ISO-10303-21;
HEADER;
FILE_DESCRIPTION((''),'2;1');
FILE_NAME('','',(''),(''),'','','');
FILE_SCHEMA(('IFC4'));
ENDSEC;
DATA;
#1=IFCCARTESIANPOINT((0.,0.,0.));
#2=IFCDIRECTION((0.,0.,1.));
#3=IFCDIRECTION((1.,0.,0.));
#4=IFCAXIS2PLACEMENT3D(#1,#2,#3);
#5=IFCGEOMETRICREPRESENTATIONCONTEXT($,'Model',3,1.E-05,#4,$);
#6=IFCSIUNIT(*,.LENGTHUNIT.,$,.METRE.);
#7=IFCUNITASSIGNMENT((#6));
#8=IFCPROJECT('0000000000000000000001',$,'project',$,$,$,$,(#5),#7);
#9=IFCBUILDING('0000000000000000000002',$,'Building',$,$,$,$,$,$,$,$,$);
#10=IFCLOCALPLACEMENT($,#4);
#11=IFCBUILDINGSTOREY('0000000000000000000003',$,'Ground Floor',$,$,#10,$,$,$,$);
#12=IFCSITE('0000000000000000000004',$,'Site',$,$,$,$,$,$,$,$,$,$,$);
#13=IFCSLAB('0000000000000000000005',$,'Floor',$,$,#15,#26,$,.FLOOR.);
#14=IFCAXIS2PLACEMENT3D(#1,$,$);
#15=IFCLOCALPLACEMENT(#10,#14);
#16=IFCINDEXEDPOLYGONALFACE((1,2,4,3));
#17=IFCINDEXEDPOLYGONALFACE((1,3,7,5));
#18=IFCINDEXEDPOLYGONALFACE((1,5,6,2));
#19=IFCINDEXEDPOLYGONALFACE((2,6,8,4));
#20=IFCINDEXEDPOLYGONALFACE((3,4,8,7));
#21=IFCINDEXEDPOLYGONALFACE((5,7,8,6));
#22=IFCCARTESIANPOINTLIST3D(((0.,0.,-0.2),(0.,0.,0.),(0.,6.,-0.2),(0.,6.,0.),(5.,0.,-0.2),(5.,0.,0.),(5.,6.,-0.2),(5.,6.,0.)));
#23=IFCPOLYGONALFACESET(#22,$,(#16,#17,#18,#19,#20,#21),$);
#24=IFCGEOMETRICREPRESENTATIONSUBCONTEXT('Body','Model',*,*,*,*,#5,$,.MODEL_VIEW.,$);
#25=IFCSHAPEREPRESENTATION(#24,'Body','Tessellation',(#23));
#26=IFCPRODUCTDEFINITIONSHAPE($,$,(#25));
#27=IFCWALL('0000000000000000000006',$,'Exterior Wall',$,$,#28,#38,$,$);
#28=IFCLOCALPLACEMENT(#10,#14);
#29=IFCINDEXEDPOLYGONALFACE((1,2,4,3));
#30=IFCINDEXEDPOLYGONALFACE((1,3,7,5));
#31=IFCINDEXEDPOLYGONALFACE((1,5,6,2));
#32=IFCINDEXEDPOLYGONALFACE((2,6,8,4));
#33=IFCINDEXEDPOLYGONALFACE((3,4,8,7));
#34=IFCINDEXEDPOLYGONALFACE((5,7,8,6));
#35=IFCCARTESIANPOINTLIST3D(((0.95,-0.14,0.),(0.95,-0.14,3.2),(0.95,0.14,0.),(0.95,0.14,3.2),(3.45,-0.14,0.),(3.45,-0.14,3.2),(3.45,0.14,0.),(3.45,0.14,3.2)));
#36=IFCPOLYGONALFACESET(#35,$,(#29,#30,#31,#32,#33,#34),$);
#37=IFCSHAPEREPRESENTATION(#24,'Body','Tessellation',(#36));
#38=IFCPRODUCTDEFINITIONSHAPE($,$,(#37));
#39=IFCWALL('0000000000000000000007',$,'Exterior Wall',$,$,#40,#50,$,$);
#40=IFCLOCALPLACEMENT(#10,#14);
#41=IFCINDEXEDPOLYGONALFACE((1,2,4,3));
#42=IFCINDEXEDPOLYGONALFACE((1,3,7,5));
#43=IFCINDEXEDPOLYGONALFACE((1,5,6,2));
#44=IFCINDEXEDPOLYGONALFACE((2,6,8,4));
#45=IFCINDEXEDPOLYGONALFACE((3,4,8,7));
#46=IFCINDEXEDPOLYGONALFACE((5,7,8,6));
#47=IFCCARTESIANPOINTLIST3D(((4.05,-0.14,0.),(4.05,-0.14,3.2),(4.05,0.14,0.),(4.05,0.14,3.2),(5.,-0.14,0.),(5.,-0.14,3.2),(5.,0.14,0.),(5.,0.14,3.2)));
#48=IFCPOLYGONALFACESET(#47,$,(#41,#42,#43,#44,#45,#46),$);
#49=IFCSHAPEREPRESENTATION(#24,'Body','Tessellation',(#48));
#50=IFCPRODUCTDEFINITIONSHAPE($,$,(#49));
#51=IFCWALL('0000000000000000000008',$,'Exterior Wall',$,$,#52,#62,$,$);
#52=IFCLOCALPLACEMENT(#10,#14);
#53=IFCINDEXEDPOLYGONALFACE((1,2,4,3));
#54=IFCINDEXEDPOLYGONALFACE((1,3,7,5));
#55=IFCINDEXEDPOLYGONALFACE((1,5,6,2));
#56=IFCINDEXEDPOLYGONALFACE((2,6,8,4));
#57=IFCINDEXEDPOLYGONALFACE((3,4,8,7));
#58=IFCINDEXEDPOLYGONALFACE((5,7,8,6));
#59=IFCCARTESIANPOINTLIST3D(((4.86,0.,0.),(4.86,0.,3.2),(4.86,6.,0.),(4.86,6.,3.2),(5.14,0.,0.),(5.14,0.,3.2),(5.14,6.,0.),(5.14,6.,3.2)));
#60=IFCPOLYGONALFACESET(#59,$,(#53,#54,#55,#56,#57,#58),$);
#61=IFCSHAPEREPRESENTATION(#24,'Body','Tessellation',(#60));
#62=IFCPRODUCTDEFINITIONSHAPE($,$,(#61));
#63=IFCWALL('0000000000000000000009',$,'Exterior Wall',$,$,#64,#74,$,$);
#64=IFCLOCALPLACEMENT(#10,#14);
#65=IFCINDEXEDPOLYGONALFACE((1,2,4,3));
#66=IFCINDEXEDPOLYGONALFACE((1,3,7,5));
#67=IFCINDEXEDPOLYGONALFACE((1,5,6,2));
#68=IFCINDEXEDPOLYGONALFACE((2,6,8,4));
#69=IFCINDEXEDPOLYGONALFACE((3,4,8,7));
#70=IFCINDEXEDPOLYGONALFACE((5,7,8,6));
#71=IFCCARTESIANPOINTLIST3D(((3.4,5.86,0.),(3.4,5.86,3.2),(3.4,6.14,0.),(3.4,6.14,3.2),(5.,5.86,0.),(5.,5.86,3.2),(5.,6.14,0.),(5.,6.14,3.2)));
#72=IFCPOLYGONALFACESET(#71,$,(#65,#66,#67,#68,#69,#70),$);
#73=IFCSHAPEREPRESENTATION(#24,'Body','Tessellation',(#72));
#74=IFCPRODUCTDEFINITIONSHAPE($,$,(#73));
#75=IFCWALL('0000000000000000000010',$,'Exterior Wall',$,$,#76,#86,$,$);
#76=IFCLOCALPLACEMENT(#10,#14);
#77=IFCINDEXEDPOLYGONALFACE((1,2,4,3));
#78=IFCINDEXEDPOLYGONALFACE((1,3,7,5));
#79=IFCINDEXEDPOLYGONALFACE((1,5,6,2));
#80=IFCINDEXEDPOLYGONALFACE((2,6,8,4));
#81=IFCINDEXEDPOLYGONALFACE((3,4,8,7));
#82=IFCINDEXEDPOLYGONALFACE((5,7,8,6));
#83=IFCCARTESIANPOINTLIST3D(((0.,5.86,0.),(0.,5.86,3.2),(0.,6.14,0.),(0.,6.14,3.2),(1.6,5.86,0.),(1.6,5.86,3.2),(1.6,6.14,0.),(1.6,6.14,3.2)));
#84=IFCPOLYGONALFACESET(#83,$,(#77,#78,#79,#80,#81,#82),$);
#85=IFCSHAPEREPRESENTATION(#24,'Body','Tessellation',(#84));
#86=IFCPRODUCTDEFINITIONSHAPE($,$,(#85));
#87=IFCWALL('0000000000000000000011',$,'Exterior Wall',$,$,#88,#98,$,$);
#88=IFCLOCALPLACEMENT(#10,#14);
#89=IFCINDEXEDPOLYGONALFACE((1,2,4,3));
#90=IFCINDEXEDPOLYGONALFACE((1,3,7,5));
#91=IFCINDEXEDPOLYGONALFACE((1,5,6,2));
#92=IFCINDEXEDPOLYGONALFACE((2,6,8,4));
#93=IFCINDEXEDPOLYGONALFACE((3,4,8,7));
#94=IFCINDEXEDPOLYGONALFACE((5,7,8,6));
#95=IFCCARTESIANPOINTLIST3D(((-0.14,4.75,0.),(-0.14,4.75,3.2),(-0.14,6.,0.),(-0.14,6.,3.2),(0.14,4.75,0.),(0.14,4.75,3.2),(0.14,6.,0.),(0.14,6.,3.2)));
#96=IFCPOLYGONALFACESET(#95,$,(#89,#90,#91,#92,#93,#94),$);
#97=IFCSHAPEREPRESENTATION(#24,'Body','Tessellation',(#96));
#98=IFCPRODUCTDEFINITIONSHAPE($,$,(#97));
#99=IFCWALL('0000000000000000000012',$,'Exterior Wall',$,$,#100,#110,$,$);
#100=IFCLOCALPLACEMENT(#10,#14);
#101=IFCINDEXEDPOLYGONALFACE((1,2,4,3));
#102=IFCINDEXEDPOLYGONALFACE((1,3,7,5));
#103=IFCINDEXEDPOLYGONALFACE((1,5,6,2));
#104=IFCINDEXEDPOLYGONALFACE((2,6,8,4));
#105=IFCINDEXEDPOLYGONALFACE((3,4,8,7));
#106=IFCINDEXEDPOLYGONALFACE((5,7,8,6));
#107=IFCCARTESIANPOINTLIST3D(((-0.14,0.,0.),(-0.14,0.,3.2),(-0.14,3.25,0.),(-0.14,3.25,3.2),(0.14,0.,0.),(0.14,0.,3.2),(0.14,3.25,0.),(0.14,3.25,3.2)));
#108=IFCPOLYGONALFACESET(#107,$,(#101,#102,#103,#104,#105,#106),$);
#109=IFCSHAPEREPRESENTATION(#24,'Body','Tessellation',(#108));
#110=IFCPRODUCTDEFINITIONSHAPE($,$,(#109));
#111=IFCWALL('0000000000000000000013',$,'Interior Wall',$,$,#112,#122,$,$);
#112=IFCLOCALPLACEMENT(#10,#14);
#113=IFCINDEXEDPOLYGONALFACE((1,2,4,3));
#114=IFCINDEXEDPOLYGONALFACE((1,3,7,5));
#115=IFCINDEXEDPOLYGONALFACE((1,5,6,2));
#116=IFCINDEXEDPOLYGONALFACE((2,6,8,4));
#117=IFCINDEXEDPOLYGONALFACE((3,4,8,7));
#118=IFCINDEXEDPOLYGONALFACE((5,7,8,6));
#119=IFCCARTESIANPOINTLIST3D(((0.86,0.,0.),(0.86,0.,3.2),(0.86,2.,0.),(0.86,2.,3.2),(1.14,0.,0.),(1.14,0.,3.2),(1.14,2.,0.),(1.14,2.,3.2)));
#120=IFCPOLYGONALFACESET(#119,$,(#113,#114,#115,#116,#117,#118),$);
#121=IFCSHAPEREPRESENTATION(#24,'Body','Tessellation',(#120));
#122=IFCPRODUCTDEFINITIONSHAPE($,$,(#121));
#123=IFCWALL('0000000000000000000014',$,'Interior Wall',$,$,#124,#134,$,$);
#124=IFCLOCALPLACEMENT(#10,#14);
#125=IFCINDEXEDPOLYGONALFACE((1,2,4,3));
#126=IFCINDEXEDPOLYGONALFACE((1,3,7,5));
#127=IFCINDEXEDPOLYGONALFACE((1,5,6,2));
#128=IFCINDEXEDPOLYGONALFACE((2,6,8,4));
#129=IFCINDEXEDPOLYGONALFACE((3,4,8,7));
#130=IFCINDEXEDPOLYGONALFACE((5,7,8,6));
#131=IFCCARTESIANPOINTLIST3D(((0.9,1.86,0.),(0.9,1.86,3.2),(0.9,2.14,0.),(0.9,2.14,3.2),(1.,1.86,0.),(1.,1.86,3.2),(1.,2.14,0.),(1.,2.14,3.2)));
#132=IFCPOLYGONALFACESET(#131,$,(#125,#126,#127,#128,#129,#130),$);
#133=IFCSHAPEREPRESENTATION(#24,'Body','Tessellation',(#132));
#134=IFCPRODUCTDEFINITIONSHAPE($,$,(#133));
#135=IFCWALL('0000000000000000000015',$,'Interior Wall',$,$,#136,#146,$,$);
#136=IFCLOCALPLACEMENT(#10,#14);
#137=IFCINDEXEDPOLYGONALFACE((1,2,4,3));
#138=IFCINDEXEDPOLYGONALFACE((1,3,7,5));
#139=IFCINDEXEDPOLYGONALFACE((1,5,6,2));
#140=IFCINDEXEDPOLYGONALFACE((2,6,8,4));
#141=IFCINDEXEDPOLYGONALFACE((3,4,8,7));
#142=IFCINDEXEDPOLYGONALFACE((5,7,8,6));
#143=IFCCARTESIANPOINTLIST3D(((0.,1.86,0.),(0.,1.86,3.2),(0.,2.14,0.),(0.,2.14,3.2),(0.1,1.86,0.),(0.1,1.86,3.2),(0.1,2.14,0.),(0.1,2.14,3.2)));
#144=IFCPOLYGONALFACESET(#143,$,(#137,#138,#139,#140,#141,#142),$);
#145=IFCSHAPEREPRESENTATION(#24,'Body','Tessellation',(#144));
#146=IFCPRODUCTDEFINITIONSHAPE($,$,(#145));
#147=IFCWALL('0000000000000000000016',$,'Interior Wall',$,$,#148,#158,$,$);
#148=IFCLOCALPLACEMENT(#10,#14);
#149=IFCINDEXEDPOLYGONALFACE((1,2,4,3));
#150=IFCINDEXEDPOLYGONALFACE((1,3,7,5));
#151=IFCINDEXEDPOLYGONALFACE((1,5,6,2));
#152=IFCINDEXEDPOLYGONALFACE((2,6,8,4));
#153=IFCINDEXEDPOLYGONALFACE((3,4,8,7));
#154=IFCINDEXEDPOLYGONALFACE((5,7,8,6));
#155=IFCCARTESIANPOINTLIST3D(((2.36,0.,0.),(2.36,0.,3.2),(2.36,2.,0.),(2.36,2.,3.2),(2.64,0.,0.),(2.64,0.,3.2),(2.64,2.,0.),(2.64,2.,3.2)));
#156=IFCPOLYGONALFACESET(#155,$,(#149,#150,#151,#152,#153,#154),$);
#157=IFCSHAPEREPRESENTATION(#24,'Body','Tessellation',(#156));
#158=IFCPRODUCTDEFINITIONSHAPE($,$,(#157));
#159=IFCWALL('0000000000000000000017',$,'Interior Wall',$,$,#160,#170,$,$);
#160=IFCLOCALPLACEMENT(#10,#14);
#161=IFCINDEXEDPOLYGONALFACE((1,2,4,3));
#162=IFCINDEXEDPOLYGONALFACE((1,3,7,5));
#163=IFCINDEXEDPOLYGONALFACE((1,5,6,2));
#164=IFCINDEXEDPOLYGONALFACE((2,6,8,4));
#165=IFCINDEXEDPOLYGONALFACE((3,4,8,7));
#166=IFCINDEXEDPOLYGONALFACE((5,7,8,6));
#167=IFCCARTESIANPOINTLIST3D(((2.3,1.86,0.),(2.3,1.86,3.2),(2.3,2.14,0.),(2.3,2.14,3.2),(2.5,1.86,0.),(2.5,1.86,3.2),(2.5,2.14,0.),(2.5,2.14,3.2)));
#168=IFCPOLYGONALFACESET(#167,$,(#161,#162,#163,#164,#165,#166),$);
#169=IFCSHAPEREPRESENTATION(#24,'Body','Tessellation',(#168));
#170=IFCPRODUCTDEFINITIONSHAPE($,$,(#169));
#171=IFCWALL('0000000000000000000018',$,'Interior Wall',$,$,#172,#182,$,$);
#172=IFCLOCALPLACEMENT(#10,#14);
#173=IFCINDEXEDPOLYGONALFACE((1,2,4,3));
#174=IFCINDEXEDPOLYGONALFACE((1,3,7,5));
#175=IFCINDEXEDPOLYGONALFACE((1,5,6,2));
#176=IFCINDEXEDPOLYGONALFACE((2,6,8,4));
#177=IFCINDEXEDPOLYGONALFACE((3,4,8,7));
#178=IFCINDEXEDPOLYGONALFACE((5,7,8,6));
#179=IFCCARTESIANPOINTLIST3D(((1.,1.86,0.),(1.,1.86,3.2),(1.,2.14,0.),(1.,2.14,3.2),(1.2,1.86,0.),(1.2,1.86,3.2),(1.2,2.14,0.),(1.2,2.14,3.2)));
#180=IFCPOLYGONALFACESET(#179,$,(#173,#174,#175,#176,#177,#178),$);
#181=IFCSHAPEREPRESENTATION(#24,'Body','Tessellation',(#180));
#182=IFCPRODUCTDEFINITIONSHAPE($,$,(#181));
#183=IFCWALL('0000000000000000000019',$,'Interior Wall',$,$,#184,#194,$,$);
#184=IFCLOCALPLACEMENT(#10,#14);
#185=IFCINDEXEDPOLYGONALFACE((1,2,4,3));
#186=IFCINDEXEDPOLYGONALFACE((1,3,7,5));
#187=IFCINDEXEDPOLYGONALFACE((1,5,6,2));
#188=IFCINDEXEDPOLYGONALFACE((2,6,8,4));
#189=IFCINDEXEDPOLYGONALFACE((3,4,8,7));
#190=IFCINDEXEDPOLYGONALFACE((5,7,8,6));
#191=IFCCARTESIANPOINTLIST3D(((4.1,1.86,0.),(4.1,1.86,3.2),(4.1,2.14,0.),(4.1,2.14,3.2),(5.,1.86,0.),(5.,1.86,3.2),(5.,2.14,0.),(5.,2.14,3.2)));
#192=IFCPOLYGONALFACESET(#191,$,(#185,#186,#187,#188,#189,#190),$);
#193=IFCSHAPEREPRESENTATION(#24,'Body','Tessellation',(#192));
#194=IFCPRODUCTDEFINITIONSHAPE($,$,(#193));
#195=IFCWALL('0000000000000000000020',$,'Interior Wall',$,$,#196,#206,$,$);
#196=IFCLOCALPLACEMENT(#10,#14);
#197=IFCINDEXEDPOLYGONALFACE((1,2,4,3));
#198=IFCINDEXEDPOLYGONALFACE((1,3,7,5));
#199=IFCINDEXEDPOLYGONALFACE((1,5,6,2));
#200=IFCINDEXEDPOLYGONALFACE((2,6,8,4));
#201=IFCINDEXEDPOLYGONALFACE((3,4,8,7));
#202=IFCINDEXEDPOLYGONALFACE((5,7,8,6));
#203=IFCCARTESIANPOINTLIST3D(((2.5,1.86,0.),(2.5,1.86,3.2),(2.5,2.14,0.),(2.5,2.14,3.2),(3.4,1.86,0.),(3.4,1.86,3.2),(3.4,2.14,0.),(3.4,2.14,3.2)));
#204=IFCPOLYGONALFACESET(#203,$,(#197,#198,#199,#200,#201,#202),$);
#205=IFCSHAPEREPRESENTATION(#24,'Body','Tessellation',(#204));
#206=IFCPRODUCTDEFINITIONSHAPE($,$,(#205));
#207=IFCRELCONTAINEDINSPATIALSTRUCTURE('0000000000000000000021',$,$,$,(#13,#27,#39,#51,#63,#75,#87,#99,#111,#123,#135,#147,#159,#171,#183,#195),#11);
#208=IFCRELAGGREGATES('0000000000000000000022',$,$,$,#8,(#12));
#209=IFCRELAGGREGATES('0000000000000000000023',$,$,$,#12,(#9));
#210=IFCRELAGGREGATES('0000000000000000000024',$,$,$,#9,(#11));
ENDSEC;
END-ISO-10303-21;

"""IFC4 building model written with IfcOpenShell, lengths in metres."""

from ifc_helpers import new_model, si_unit, frame, origin_with_axes, place, context, subcontext, project, spatial, indexed_curve, outline, extrude, element, save


model = new_model("IFC4")

# Units and contexts
model_context = context("Model", 3, precision=1e-05, world=origin_with_axes())
body_context = subcontext(model_context, "Body", "Model", "MODEL_VIEW")
ifc_project = project(units=[si_unit("LENGTHUNIT", "METRE")], contexts=[model_context])

# Site, building, storey
site = spatial("IfcSite", under=ifc_project, Name="Site")
building = spatial("IfcBuilding", under=site, Name="Building")
storey_placement = place(None, origin_with_axes())
storey = spatial("IfcBuildingStorey", under=building, at=storey_placement, Name="Ground Floor")

# Slab
slab_placement = place(storey_placement, frame((0.0, 0.0, -0.2), z_axis=(0.0, 0.0, 1.0), x_axis=(1.0, 0.0, 0.0)))
element("IfcSlab", 1, at=slab_placement, inside=storey, Name="Floor", PredefinedType="FLOOR", context=body_context, shape_type="SweptSolid", body=[
    extrude(outline(indexed_curve([(0.0, 0.0), (5.0, 0.0), (5.0, 6.0), (0.0, 6.0)])), None, (0.0, 0.0, 1.0), 0.2),
])

# Walls
wall_1_placement = place(storey_placement, frame((0.95, 0.0, 0.0), z_axis=(0.0, 0.0, 1.0), x_axis=(1.0, 0.0, 0.0)))
element("IfcWall", 2, at=wall_1_placement, inside=storey, Name="Exterior Wall", context=body_context, shape_type="SweptSolid", body=[
    extrude(outline(indexed_curve([(0.0, 0.0), (0.0, 0.28), (2.5, 0.28), (2.5, 0.0), (0.0, 0.0)], self_intersect=False)), frame((0.0, -0.14, 0.0), z_axis=(0.0, 0.0, 1.0), x_axis=(1.0, 0.0, 0.0)), (0.0, 0.0, 1.0), 3.2),
])
wall_2_placement = place(storey_placement, frame((4.05, 0.0, 0.0), z_axis=(0.0, 0.0, 1.0), x_axis=(1.0, 0.0, 0.0)))
element("IfcWall", 3, at=wall_2_placement, inside=storey, Name="Exterior Wall", context=body_context, shape_type="SweptSolid", body=[
    extrude(outline(indexed_curve([(0.0, 0.0), (0.0, 0.28), (0.95, 0.28), (0.95, 0.0), (0.0, 0.0)], self_intersect=False)), frame((0.0, -0.14, 0.0), z_axis=(0.0, 0.0, 1.0), x_axis=(1.0, 0.0, 0.0)), (0.0, 0.0, 1.0), 3.2),
])
wall_3_placement = place(storey_placement, frame((5.0, 0.0, 0.0), z_axis=(0.0, 0.0, 1.0), x_axis=(0.0, 1.0, 0.0)))
element("IfcWall", 4, at=wall_3_placement, inside=storey, Name="Exterior Wall", context=body_context, shape_type="SweptSolid", body=[
    extrude(outline(indexed_curve([(0.0, 0.0), (0.0, 0.28), (6.0, 0.28), (6.0, 0.0), (0.0, 0.0)], self_intersect=False)), frame((0.0, -0.14, 0.0), z_axis=(0.0, 0.0, 1.0), x_axis=(1.0, 0.0, 0.0)), (0.0, 0.0, 1.0), 3.2),
])
for number, where, z_axis, x_axis, name in (
    (5, (5.0, 6.0, 0.0), (0.0, 0.0, 1.0), (-1.0, 0.0, 0.0), "Exterior Wall"),
    (6, (1.6, 6.0, 0.0), (0.0, 0.0, 1.0), (-1.0, 0.0, 0.0), "Exterior Wall"),
):
    element("IfcWall", number, at=place(storey_placement, frame(where, z_axis=z_axis, x_axis=x_axis)), inside=storey, Name=name, context=body_context, shape_type="SweptSolid", body=[
        extrude(outline(indexed_curve([(0.0, 0.0), (0.0, 0.28), (1.6, 0.28), (1.6, 0.0), (0.0, 0.0)], self_intersect=False)), frame((0.0, -0.14, 0.0), z_axis=(0.0, 0.0, 1.0), x_axis=(1.0, 0.0, 0.0)), (0.0, 0.0, 1.0), 3.2),
    ])
wall_4_placement = place(storey_placement, frame((0.0, 6.0, 0.0), z_axis=(0.0, 0.0, 1.0), x_axis=(0.0, -1.0, 0.0)))
element("IfcWall", 7, at=wall_4_placement, inside=storey, Name="Exterior Wall", context=body_context, shape_type="SweptSolid", body=[
    extrude(outline(indexed_curve([(0.0, 0.0), (0.0, 0.28), (1.25, 0.28), (1.25, 0.0), (0.0, 0.0)], self_intersect=False)), frame((0.0, -0.14, 0.0), z_axis=(0.0, 0.0, 1.0), x_axis=(1.0, 0.0, 0.0)), (0.0, 0.0, 1.0), 3.2),
])
wall_5_placement = place(storey_placement, frame((0.0, 3.25, 0.0), z_axis=(0.0, 0.0, 1.0), x_axis=(0.0, -1.0, 0.0)))
element("IfcWall", 8, at=wall_5_placement, inside=storey, Name="Exterior Wall", context=body_context, shape_type="SweptSolid", body=[
    extrude(outline(indexed_curve([(0.0, 0.0), (0.0, 0.28), (3.25, 0.28), (3.25, 0.0), (0.0, 0.0)], self_intersect=False)), frame((0.0, -0.14, 0.0), z_axis=(0.0, 0.0, 1.0), x_axis=(1.0, 0.0, 0.0)), (0.0, 0.0, 1.0), 3.2),
])
wall_6_placement = place(storey_placement, frame((1.0, 0.0, 0.0), z_axis=(0.0, 0.0, 1.0), x_axis=(0.0, 1.0, 0.0)))
element("IfcWall", 9, at=wall_6_placement, inside=storey, Name="Interior Wall", context=body_context, shape_type="SweptSolid", body=[
    extrude(outline(indexed_curve([(0.0, 0.0), (0.0, 0.28), (2.0, 0.28), (2.0, 0.0), (0.0, 0.0)], self_intersect=False)), frame((0.0, -0.14, 0.0), z_axis=(0.0, 0.0, 1.0), x_axis=(1.0, 0.0, 0.0)), (0.0, 0.0, 1.0), 3.2),
])
for number, where, z_axis, x_axis, name in (
    (10, (1.0, 2.0, 0.0), (0.0, 0.0, 1.0), (-1.0, 0.0, 0.0), "Interior Wall"),
    (11, (0.1, 2.0, 0.0), (0.0, 0.0, 1.0), (-1.0, 0.0, 0.0), "Interior Wall"),
):
    element("IfcWall", number, at=place(storey_placement, frame(where, z_axis=z_axis, x_axis=x_axis)), inside=storey, Name=name, context=body_context, shape_type="SweptSolid", body=[
        extrude(outline(indexed_curve([(0.0, 0.0), (0.0, 0.28), (0.1, 0.28), (0.1, 0.0), (0.0, 0.0)], self_intersect=False)), frame((0.0, -0.14, 0.0), z_axis=(0.0, 0.0, 1.0), x_axis=(1.0, 0.0, 0.0)), (0.0, 0.0, 1.0), 3.2),
    ])
wall_7_placement = place(storey_placement, frame((2.5, 0.0, 0.0), z_axis=(0.0, 0.0, 1.0), x_axis=(0.0, 1.0, 0.0)))
element("IfcWall", 12, at=wall_7_placement, inside=storey, Name="Interior Wall", context=body_context, shape_type="SweptSolid", body=[
    extrude(outline(indexed_curve([(0.0, 0.0), (0.0, 0.28), (2.0, 0.28), (2.0, 0.0), (0.0, 0.0)], self_intersect=False)), frame((0.0, -0.14, 0.0), z_axis=(0.0, 0.0, 1.0), x_axis=(1.0, 0.0, 0.0)), (0.0, 0.0, 1.0), 3.2),
])
wall_8_placement = place(storey_placement, frame((2.5, 2.0, 0.0), z_axis=(0.0, 0.0, 1.0), x_axis=(-1.0, 0.0, 0.0)))
element("IfcWall", 13, at=wall_8_placement, inside=storey, Name="Interior Wall", context=body_context, shape_type="SweptSolid", body=[
    extrude(outline(indexed_curve([(0.0, 0.0), (0.0, 0.28), (0.2, 0.28), (0.2, 0.0), (0.0, 0.0)], self_intersect=False)), frame((0.0, -0.14, 0.0), z_axis=(0.0, 0.0, 1.0), x_axis=(1.0, 0.0, 0.0)), (0.0, 0.0, 1.0), 3.2),
])
wall_9_placement = place(storey_placement, frame((1.2, 2.0, 0.0), z_axis=(0.0, 0.0, 1.0), x_axis=(-1.0, 0.0, 0.0)))
element("IfcWall", 14, at=wall_9_placement, inside=storey, Name="Interior Wall", context=body_context, shape_type="SweptSolid", body=[
    extrude(outline(indexed_curve([(0.0, 0.0), (0.0, 0.28), (0.2, 0.28), (0.2, 0.0), (0.0, 0.0)], self_intersect=False)), frame((0.0, -0.14, 0.0), z_axis=(0.0, 0.0, 1.0), x_axis=(1.0, 0.0, 0.0)), (0.0, 0.0, 1.0), 3.2),
])
wall_10_placement = place(storey_placement, frame((5.0, 2.0, 0.0), z_axis=(0.0, 0.0, 1.0), x_axis=(-1.0, 0.0, 0.0)))
element("IfcWall", 15, at=wall_10_placement, inside=storey, Name="Interior Wall", context=body_context, shape_type="SweptSolid", body=[
    extrude(outline(indexed_curve([(0.0, 0.0), (0.0, 0.28), (0.9, 0.28), (0.9, 0.0), (0.0, 0.0)], self_intersect=False)), frame((0.0, -0.14, 0.0), z_axis=(0.0, 0.0, 1.0), x_axis=(1.0, 0.0, 0.0)), (0.0, 0.0, 1.0), 3.2),
])
wall_11_placement = place(storey_placement, frame((3.4, 2.0, 0.0), z_axis=(0.0, 0.0, 1.0), x_axis=(-1.0, 0.0, 0.0)))
element("IfcWall", 16, at=wall_11_placement, inside=storey, Name="Interior Wall", context=body_context, shape_type="SweptSolid", body=[
    extrude(outline(indexed_curve([(0.0, 0.0), (0.0, 0.28), (0.9, 0.28), (0.9, 0.0), (0.0, 0.0)], self_intersect=False)), frame((0.0, -0.14, 0.0), z_axis=(0.0, 0.0, 1.0), x_axis=(1.0, 0.0, 0.0)), (0.0, 0.0, 1.0), 3.2),
])

save(model, "model.ifc")
